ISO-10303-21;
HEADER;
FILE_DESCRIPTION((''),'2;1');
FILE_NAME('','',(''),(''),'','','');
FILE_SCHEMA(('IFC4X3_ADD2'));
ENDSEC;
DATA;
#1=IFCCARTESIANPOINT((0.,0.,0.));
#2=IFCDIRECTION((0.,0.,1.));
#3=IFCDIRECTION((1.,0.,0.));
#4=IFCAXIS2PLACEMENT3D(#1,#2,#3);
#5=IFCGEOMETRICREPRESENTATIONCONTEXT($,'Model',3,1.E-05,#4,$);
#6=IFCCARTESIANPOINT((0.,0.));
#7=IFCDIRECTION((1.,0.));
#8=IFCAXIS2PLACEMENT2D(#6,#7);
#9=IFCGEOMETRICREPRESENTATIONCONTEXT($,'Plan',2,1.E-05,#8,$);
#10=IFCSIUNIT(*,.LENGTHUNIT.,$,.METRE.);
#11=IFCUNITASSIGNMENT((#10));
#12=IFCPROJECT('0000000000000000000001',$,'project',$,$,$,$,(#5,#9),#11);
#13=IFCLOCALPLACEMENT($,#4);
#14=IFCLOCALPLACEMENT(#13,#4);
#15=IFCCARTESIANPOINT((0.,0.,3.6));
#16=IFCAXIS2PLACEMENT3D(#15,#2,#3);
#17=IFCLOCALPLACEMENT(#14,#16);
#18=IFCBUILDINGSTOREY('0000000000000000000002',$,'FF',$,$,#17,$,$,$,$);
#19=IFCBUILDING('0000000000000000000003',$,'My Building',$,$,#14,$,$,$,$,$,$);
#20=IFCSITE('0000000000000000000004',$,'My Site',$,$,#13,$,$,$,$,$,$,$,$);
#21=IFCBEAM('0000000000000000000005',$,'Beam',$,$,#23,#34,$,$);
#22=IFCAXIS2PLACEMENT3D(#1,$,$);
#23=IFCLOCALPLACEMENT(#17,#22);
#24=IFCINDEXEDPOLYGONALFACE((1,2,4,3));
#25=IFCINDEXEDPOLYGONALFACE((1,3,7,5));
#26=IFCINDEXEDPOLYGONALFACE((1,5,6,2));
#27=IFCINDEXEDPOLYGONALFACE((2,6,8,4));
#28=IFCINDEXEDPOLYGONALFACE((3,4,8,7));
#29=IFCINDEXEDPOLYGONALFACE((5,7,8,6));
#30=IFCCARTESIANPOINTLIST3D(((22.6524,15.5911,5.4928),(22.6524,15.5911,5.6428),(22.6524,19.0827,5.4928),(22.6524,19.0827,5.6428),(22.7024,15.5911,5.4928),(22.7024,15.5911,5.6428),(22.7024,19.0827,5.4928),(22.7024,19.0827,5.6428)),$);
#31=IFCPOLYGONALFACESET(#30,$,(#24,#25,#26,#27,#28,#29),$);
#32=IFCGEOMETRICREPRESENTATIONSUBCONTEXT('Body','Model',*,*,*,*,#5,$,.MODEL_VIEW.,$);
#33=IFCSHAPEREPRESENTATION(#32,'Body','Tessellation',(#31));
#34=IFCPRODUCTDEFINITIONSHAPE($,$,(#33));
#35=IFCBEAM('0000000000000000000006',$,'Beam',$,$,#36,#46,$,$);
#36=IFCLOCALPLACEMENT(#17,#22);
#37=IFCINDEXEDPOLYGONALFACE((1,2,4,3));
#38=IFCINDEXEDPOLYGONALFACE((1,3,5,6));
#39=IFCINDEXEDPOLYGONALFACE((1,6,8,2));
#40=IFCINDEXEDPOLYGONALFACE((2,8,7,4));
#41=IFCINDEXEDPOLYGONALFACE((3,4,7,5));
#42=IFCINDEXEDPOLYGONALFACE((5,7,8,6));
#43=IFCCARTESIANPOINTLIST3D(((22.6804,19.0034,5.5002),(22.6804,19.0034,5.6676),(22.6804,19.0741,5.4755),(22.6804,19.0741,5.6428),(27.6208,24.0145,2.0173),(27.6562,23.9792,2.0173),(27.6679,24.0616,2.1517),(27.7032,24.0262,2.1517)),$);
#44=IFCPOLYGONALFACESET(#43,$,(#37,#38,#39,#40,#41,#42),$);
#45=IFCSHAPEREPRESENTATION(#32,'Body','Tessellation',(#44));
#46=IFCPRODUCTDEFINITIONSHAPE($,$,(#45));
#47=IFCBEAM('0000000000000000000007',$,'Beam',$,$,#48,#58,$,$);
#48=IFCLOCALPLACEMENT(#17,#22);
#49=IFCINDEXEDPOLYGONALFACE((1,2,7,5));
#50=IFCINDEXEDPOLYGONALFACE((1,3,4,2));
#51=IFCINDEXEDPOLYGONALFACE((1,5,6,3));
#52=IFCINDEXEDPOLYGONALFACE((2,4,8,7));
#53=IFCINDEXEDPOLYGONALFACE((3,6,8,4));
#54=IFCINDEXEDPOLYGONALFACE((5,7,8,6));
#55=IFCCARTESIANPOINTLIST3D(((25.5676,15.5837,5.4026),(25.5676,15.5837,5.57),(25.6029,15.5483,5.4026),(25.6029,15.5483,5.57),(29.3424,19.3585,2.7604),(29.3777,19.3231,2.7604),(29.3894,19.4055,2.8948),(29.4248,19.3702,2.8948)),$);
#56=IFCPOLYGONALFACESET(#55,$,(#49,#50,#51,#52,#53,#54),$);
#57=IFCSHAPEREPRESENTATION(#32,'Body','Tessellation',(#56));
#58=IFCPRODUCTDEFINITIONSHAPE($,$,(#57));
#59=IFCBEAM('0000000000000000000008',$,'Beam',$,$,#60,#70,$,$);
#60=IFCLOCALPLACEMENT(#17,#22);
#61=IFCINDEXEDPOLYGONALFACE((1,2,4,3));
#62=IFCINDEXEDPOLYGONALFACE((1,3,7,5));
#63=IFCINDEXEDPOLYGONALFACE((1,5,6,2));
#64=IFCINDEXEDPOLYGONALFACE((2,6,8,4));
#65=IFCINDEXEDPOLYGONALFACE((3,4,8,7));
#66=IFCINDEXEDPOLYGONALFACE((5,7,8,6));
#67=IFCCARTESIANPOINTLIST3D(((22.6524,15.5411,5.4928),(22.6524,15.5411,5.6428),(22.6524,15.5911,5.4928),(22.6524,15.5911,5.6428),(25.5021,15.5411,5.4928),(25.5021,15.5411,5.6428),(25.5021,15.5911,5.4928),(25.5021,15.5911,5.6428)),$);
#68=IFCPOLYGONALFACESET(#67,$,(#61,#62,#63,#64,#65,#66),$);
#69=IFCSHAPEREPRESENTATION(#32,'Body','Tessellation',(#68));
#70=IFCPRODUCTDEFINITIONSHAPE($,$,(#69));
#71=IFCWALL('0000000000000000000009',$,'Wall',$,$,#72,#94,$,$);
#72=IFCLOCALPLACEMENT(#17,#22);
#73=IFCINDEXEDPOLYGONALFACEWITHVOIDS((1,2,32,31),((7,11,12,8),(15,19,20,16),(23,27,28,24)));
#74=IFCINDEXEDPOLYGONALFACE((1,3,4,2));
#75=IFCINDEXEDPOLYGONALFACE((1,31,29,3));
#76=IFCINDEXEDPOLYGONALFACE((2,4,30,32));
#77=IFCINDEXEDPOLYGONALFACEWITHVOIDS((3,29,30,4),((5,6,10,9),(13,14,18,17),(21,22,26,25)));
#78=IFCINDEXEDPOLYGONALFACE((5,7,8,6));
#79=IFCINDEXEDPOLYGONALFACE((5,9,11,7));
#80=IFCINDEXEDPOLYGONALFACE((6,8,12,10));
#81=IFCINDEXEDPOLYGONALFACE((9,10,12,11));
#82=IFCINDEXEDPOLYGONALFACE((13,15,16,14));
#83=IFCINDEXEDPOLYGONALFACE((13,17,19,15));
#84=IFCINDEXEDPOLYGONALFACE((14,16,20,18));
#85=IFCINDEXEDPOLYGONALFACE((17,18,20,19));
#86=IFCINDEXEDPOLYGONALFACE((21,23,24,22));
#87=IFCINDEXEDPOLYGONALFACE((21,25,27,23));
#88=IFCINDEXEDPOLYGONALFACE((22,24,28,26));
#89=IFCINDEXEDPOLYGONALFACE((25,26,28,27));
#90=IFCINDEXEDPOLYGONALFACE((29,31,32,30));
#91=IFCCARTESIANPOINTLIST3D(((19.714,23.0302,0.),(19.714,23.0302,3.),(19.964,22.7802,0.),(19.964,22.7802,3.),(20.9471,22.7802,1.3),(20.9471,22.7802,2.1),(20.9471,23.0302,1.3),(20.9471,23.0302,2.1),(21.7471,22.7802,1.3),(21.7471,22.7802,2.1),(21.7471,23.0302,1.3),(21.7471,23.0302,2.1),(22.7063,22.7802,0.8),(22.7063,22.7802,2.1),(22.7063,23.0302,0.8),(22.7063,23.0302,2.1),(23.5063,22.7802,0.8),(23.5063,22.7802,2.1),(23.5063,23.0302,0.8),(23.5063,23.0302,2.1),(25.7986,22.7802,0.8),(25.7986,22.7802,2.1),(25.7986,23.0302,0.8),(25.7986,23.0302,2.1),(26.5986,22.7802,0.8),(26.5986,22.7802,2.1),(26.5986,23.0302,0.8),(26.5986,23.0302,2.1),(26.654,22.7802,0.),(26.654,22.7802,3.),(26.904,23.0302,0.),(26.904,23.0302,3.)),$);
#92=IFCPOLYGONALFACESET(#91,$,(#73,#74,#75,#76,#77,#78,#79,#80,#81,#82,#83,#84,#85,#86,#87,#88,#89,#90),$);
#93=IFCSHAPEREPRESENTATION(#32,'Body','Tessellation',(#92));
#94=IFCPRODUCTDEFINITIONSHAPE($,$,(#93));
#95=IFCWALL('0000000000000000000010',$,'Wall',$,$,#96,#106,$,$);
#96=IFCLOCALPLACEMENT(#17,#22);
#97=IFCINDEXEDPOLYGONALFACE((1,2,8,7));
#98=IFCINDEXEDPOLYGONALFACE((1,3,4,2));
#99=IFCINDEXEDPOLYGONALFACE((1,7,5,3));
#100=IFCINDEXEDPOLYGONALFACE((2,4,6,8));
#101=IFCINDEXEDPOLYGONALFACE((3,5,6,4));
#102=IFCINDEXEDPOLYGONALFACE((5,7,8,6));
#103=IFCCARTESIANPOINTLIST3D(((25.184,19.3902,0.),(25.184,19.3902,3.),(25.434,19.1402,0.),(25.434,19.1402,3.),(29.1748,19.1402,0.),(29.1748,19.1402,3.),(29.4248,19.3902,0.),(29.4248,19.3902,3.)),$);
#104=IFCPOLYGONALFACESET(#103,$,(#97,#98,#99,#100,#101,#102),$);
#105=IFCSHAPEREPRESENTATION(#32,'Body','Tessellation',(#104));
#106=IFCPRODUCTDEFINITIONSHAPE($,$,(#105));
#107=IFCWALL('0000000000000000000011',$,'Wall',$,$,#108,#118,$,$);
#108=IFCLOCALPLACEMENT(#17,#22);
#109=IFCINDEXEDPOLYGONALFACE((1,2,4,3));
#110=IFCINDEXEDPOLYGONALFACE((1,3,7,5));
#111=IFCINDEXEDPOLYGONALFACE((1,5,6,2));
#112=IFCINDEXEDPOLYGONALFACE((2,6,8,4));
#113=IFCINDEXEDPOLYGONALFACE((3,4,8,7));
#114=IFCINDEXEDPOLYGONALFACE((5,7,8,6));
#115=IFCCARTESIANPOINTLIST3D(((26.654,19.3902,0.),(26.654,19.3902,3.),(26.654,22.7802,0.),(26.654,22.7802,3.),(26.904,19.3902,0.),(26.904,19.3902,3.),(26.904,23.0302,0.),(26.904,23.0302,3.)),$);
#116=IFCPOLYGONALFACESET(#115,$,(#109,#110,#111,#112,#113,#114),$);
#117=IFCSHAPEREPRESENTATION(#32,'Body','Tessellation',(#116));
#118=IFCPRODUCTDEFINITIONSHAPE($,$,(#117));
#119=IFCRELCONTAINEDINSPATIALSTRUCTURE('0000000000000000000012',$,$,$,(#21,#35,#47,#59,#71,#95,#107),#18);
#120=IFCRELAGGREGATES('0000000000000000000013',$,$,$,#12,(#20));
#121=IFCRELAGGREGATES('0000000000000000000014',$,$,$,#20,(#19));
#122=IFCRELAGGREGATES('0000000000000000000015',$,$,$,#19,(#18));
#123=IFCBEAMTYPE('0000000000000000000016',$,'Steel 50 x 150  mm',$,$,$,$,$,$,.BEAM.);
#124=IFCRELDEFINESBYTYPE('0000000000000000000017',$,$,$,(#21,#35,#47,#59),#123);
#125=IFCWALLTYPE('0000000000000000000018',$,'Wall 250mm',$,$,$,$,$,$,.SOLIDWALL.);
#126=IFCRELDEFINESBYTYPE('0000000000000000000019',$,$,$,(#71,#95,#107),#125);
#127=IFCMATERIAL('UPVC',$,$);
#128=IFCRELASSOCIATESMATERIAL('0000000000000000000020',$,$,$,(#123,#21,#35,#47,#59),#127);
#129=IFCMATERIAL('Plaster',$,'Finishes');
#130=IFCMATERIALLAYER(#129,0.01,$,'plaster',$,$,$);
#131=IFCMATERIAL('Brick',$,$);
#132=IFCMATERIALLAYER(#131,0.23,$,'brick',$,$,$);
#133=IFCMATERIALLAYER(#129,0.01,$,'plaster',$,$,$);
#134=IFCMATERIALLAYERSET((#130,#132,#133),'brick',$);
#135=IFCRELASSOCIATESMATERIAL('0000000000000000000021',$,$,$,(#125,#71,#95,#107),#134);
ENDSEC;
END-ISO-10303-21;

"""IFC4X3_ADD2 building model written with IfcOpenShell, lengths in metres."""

from ifc_helpers import new_model, si_unit, frame, origin_with_axes, origin_2d_with_axis, place, context, subcontext, project, spatial, line, indexed_curve, rectangle, outline, extrude, clip, halfspace, source, transform, mapped, material, layer, layer_set, layer_usage, material_profile, profile_set, profile_usage, type_object, element, save


model = new_model("IFC4X3_ADD2")

# Units and contexts
model_context = context("Model", 3, precision=1e-05, world=origin_with_axes())
plan_context = context("Plan", 2, precision=1e-05, world=origin_2d_with_axis())
body_context_1 = subcontext(model_context, "Body", "Model", "MODEL_VIEW")
ifc_project = project(units=[si_unit("LENGTHUNIT", "METRE")], contexts=[model_context, plan_context])

# Site, building, storey
site_placement = place(None, origin_with_axes())
site = spatial("IfcSite", under=ifc_project, at=site_placement, Name="My Site")
building_placement = place(site_placement, origin_with_axes())
building = spatial("IfcBuilding", under=site, at=building_placement, Name="My Building")
storey_placement = place(building_placement, frame((0.0, 0.0, 3.6), z_axis=(0.0, 0.0, 1.0), x_axis=(1.0, 0.0, 0.0)))
storey = spatial("IfcBuildingStorey", under=building, at=storey_placement, Name="FF")

# Beams
ifc_material_1 = material(Name="UPVC")
ifc_material_profile = material_profile(ifc_material_1, rectangle(XDim=0.05, YDim=0.15))
ifc_profile_set = profile_set([ifc_material_profile])
ifc_profile_usage_1 = profile_usage(ifc_profile_set)
beam_type = type_object("IfcBeamType", Name="Steel 50 x 150  mm", PredefinedType="BEAM", material=ifc_profile_set)
beam_1_placement = place(storey_placement, frame((22.6774, 19.0827, 5.5678), z_axis=(0.0, -1.0, 0.0), x_axis=(1.0, 0.0, 0.0)))
element("IfcBeam", 1, at=beam_1_placement, inside=storey, type_object=beam_type, material=ifc_profile_usage_1, Name="Beam", context=body_context_1, shape_type="SweptSolid", body=[
    extrude(rectangle(XDim=0.05, YDim=0.15), origin_with_axes(), (0.0, 0.0, 1.0), 3.4917),
])
ifc_profile_usage_2 = profile_usage(ifc_profile_set)
beam_2_placement = place(storey_placement, frame((27.662, 24.0204, 2.0845), z_axis=(-0.633729, -0.633729, 0.443593), x_axis=(0.707107, -0.707107, 0.0)))
element("IfcBeam", 2, at=beam_2_placement, inside=storey, type_object=beam_type, material=ifc_profile_usage_2, Name="Beam", context=body_context_1, shape_type="Clipping", body=[
    clip(extrude(rectangle(XDim=0.05, YDim=0.15), origin_with_axes(), (0.0, 0.0, 1.0), 8.0387), halfspace(frame((0.025, -8.2743, 3.7933), z_axis=(-0.707107, -0.313667, 0.633729), x_axis=(-0.405488, 0.9141, 0.0)), False)),
])
ifc_profile_usage_3 = profile_usage(ifc_profile_set)
beam_3_placement = place(storey_placement, frame((29.3836, 19.3643, 2.8276), z_axis=(-0.633729, -0.633729, 0.443593), x_axis=(0.707107, -0.707107, 0.0)))
element("IfcBeam", 3, at=beam_3_placement, inside=storey, type_object=beam_type, material=ifc_profile_usage_3, Name="Beam", context=body_context_1, shape_type="Clipping", body=[
    clip(extrude(rectangle(XDim=0.05, YDim=0.15), origin_with_axes(), (0.0, 0.0, 1.0), 6.1436), halfspace(frame((10.182, -4.5881, 3.7227), z_axis=(0.0, -0.443593, 0.896228), x_axis=(-1.0, -0.000001, 0.0)), False)),
])
ifc_profile_usage_4 = profile_usage(ifc_profile_set)
beam_4_placement = place(storey_placement, frame((22.6524, 15.5661, 5.5678), z_axis=(1.0, 0.0, 0.0), x_axis=(0.0, 1.0, 0.0)))
element("IfcBeam", 4, at=beam_4_placement, inside=storey, type_object=beam_type, material=ifc_profile_usage_4, Name="Beam", context=body_context_1, shape_type="SweptSolid", body=[
    extrude(rectangle(XDim=0.05, YDim=0.15), origin_with_axes(), (0.0, 0.0, 1.0), 2.8497),
])

# Wall, openings
ifc_material_2 = material(Name="Plaster", Category="Finishes")
ifc_layer_1 = layer(ifc_material_2, 0.01, Name="plaster")
ifc_material_3 = material(Name="Brick")
ifc_layer_2 = layer(ifc_material_3, 0.23, Name="brick")
ifc_layer_3 = layer(ifc_material_2, 0.01, Name="plaster")
ifc_layer_set_1 = layer_set([ifc_layer_1, ifc_layer_2, ifc_layer_3], Name="brick")
ifc_layer_usage_1 = layer_usage(ifc_layer_set_1, "AXIS2", "POSITIVE", 0.0)
wall_type_1 = type_object("IfcWallType", Name="Wall 250mm", PredefinedType="SOLIDWALL", material=ifc_layer_set_1)
wall_1_placement = place(storey_placement, frame((26.904, 23.0302, 0.0), z_axis=(0.0, 0.0, 1.0), x_axis=(-1.0, 0.0, 0.0)))
wall_1 = element("IfcWall", 5, at=wall_1_placement, inside=storey, type_object=wall_type_1, material=ifc_layer_usage_1, Name="Wall", context=body_context_1, shape_type="SweptSolid", body=[
    extrude(outline(indexed_curve([(0.0, 0.0), (0.25, 0.25), (6.94, 0.25), (7.19, 0.0)], segments=[line(1, 2, 3, 4, 1)])), origin_with_axes(), (0.0, 0.0, 1.0), 3.0),
])
shared_shape_1 = source(origin_with_axes(), body_context_1, "Body", "SweptSolid", [
    extrude(outline(indexed_curve([(0.0, 0.0), (0.8, 0.0), (0.8, 1.3), (0.0, 1.3)], segments=[line(1, 2, 3, 4, 1)])), frame((-0.4, -0.6, 0.0), z_axis=(0.0, -1.0, 0.0), x_axis=(1.0, 0.0, 0.0)), (0.0, 0.0, -1.0), 1.2),
])
opening_1_placement = place(wall_1_placement, frame((3.7977, 0.0, 0.8), z_axis=(0.0, 0.0, 1.0), x_axis=(1.0, 0.0, 0.0)))
element("IfcOpeningElement", 6, at=opening_1_placement, cuts=wall_1, PredefinedType="OPENING", context=body_context_1, shape_type="MappedRepresentation", body=[
    mapped(shared_shape_1, transform((0.0, 0.0, 0.0), x_axis=(1.0, 0.0, 0.0), y_axis=(0.0, 1.0, 0.0), z_axis=(0.0, 0.0, 1.0), scale=1.0)),
])
shared_shape_2 = source(origin_with_axes(), body_context_1, "Body", "SweptSolid", [
    extrude(outline(indexed_curve([(0.0, 0.0), (0.8, 0.0), (0.8, 0.8), (0.0, 0.8)], segments=[line(1, 2, 3, 4, 1)])), frame((-0.4, -0.6, 0.0), z_axis=(0.0, -1.0, 0.0), x_axis=(1.0, 0.0, 0.0)), (0.0, 0.0, -1.0), 1.2),
])
opening_2_placement = place(wall_1_placement, frame((5.5569, 0.0, 1.3), z_axis=(0.0, 0.0, 1.0), x_axis=(1.0, 0.0, 0.0)))
element("IfcOpeningElement", 7, at=opening_2_placement, cuts=wall_1, PredefinedType="OPENING", context=body_context_1, shape_type="MappedRepresentation", body=[
    mapped(shared_shape_2, transform((0.0, 0.0, 0.0), x_axis=(1.0, 0.0, 0.0), y_axis=(0.0, 1.0, 0.0), z_axis=(0.0, 0.0, 1.0), scale=1.0)),
])
opening_3_placement = place(wall_1_placement, frame((0.7053, 0.0, 0.8), z_axis=(0.0, 0.0, 1.0), x_axis=(1.0, 0.0, 0.0)))
element("IfcOpeningElement", 8, at=opening_3_placement, cuts=wall_1, PredefinedType="OPENING", context=body_context_1, shape_type="MappedRepresentation", body=[
    mapped(shared_shape_1, transform((0.0, 0.0, 0.0), x_axis=(1.0, 0.0, 0.0), y_axis=(0.0, 1.0, 0.0), z_axis=(0.0, 0.0, 1.0), scale=1.0)),
])

# Walls
ifc_layer_usage_2 = layer_usage(ifc_layer_set_1, "AXIS2", "NEGATIVE", 0.0)
wall_2_placement = place(storey_placement, frame((29.4248, 19.1402, 0.0), z_axis=(0.0, 0.0, 1.0), x_axis=(-1.0, 0.0, 0.0)))
element("IfcWall", 9, at=wall_2_placement, inside=storey, type_object=wall_type_1, material=ifc_layer_usage_2, Name="Wall", context=body_context_1, shape_type="SweptSolid", body=[
    extrude(outline(indexed_curve([(0.0, -0.25), (0.25, 0.0), (3.9908, 0.0), (4.2408, -0.25)], segments=[line(1, 2, 3, 4, 1)])), origin_with_axes(), (0.0, 0.0, 1.0), 3.0),
])
ifc_layer_usage_3 = layer_usage(ifc_layer_set_1, "AXIS2", "POSITIVE", 0.0)
wall_3_placement = place(storey_placement, frame((26.904, 19.1402, 0.0), z_axis=(0.0, 0.0, 1.0), x_axis=(0.000001, 1.0, 0.0)))
element("IfcWall", 10, at=wall_3_placement, inside=storey, type_object=wall_type_1, material=ifc_layer_usage_3, Name="Wall", context=body_context_1, shape_type="SweptSolid", body=[
    extrude(outline(indexed_curve([(0.25, 0.0), (0.25, 0.25), (3.64, 0.25), (3.89, 0.0)], segments=[line(1, 2, 3, 4, 1)])), origin_with_axes(), (0.0, 0.0, 1.0), 3.0),
])

save(model, "model.ifc")
